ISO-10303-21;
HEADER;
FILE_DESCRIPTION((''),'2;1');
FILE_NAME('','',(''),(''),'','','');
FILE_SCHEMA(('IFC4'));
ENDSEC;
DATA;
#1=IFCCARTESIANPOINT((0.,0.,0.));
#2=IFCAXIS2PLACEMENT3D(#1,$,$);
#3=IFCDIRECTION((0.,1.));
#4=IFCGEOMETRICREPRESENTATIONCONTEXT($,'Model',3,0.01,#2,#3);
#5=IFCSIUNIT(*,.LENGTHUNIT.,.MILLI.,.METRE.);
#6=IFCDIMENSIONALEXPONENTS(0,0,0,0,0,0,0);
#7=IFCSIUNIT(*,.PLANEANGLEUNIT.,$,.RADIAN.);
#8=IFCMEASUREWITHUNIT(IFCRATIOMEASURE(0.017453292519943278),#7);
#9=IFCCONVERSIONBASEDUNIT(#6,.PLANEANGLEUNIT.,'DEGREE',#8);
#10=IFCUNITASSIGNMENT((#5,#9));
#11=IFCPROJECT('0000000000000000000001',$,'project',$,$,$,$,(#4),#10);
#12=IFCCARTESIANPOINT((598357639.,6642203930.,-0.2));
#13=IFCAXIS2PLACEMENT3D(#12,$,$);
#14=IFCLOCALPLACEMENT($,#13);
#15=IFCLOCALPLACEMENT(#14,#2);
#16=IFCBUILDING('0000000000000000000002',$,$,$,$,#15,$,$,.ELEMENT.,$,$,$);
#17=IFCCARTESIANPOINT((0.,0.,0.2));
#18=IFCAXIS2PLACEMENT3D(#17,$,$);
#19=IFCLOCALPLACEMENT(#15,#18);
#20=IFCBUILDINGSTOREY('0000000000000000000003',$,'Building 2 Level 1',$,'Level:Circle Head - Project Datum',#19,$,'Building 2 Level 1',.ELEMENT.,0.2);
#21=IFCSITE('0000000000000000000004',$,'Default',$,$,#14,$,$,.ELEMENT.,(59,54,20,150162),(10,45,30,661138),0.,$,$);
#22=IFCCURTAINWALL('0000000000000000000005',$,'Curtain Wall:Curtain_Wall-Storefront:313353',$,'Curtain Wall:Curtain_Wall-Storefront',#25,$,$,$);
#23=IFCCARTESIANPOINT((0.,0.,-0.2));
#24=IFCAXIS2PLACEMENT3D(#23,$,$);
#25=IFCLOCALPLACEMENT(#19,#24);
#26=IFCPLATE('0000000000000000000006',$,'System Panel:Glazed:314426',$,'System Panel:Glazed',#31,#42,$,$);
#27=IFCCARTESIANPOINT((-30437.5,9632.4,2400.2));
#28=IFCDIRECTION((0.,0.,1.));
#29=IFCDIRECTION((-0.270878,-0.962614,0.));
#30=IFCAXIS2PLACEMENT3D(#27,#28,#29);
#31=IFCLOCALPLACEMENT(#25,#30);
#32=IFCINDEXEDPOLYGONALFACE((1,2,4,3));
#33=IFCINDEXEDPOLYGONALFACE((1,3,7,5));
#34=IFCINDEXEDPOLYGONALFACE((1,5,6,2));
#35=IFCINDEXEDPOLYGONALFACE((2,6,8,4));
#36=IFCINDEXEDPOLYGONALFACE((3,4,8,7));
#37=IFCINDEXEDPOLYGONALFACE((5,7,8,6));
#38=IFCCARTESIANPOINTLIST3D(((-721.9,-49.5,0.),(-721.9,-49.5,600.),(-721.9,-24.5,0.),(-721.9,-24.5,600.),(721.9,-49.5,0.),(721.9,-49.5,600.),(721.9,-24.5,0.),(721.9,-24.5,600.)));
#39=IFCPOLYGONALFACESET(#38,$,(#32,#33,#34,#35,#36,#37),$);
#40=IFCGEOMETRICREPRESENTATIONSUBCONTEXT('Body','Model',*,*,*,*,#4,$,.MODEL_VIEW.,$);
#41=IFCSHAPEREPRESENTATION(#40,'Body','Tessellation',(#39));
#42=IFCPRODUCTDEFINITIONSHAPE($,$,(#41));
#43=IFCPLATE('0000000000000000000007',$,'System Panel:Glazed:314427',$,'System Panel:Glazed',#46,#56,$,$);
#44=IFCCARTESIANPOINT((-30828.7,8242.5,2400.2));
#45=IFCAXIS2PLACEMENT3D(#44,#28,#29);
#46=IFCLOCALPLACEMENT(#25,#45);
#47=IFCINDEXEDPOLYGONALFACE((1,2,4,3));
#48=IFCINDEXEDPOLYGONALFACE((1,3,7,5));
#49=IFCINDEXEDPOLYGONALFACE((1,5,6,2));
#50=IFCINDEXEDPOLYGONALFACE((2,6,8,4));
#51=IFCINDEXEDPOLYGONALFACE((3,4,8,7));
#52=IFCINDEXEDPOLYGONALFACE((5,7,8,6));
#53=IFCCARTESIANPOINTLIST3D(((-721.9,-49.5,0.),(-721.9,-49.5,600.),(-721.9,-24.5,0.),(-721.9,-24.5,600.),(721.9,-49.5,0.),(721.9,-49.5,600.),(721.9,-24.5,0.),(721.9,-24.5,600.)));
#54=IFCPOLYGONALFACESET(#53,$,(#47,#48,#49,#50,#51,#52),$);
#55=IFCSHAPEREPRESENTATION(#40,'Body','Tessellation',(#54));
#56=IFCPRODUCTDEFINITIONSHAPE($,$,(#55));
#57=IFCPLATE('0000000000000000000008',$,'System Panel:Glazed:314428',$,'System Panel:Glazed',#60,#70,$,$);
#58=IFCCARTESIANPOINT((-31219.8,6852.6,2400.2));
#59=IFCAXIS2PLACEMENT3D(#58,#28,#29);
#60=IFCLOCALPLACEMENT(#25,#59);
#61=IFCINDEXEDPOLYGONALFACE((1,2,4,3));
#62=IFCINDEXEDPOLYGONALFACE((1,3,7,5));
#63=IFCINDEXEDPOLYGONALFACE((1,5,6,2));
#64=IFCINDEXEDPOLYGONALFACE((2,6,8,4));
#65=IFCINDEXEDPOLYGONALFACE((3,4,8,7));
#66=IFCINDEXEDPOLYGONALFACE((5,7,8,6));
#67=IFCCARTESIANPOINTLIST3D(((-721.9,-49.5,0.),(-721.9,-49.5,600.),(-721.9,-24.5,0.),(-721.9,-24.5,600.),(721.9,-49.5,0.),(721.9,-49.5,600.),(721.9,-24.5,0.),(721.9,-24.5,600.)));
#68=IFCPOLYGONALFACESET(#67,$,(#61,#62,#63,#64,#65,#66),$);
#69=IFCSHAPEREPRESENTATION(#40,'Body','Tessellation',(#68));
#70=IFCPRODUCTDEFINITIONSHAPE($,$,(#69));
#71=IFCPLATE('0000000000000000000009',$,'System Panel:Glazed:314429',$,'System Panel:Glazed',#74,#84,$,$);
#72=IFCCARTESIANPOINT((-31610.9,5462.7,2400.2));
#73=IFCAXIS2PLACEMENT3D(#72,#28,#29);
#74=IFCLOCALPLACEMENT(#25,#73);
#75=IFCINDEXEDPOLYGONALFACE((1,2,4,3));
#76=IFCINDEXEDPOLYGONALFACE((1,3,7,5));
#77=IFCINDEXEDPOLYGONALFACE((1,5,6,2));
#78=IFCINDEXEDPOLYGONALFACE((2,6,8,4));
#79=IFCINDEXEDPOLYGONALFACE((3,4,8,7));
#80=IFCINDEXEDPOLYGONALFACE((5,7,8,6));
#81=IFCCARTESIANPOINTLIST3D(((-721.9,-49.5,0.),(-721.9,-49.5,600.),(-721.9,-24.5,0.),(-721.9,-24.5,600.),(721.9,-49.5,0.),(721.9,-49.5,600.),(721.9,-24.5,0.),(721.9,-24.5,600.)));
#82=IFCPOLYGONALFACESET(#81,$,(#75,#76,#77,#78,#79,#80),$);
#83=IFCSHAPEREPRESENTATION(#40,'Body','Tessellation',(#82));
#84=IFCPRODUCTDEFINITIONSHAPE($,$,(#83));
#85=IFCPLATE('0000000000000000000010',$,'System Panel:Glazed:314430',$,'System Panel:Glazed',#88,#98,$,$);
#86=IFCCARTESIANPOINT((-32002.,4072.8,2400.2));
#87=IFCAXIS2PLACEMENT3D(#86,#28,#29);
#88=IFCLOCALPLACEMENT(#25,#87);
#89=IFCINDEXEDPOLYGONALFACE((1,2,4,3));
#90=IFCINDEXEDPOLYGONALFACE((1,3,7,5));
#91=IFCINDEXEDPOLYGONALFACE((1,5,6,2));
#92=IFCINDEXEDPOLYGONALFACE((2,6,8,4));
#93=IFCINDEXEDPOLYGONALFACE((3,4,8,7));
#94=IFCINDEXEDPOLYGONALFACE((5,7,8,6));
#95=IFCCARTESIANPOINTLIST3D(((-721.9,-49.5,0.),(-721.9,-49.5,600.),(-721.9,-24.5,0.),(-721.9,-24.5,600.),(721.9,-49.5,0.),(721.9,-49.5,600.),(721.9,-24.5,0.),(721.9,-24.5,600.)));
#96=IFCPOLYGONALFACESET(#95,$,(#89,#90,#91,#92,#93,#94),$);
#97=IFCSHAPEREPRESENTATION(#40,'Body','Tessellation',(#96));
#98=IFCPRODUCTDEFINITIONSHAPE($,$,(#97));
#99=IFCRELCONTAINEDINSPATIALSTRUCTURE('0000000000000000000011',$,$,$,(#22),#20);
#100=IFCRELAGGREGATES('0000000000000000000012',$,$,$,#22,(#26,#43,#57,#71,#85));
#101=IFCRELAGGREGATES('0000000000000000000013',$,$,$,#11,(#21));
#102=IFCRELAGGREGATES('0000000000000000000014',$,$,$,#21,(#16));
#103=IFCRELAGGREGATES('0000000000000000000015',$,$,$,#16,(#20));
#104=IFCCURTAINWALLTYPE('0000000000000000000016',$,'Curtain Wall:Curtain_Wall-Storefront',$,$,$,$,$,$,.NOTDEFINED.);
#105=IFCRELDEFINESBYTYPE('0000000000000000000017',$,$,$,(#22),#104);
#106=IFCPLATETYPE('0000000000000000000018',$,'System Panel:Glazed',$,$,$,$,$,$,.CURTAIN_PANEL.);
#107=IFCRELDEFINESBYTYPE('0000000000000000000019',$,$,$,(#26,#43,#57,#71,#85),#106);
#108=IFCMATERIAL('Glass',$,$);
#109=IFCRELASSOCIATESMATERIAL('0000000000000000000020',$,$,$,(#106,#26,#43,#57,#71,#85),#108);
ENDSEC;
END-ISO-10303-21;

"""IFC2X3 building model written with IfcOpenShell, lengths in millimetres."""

from ifc_helpers import new_model, entity, si_unit, converted_unit, direction, frame, frame_2d, origin, place, context, subcontext, project, spatial, rectangle, extrude, source, transform, mapped, material, type_object, type_shapes, element, aggregate, save


model = new_model("IFC2X3")

# Units and contexts
model_context = context("Model", 3, precision=0.01, world=origin(), true_north=direction((0.0, 1.0)))
body_context = subcontext(model_context, "Body", "Model", "MODEL_VIEW")
ifc_project = project(units=[si_unit("LENGTHUNIT", "METRE", prefix="MILLI"), converted_unit("PLANEANGLEUNIT", "DEGREE", entity("IfcRatioMeasure", 0.017453292519943278), si_unit("PLANEANGLEUNIT", "RADIAN"), dimensions=[0, 0, 0, 0, 0, 0, 0])], contexts=[model_context])

# Site, building, storey
site_placement = place(None, frame((598357639.0, 6642203930.0, -0.2)))
site = spatial("IfcSite", under=ifc_project, at=site_placement, Name="Default", CompositionType="ELEMENT", RefLatitude=(59, 54, 20, 150162), RefLongitude=(10, 45, 30, 661138), RefElevation=0.0)
building_placement = place(site_placement, origin())
building = spatial("IfcBuilding", under=site, at=building_placement, CompositionType="ELEMENT")
storey_placement = place(building_placement, frame((0.0, 0.0, 0.2)))
storey = spatial("IfcBuildingStorey", under=building, at=storey_placement, Name="Building 2 Level 1", ObjectType="Level:Circle Head - Project Datum", LongName="Building 2 Level 1", CompositionType="ELEMENT", Elevation=0.2)

# Curtain wall, plates
curtain_wall_type = type_object("IfcCurtainWallType", Name="Curtain Wall:Curtain_Wall-Storefront", PredefinedType="NOTDEFINED")
ifc_material = material(Name="Glass")
curtain_wall_1_placement = place(storey_placement, frame((0.0, 0.0, -0.2)))
curtain_wall_1 = element("IfcCurtainWall", 1, at=curtain_wall_1_placement, inside=storey, type_object=curtain_wall_type, Name="Curtain Wall:Curtain_Wall-Storefront:313353", ObjectType="Curtain Wall:Curtain_Wall-Storefront")
plate_type_1 = type_object("IfcPlateType", Name="System Panel:Glazed", PredefinedType="CURTAIN_PANEL", material=ifc_material)
shared_shape_1 = source(origin(), body_context, "Body", "SweptSolid", [
    extrude(rectangle(XDim=25.0, YDim=1443.9, at=frame_2d((0.0, 0.0), x_axis=(1.0, 0.0))), frame((0.0, -37.0, 0.0), z_axis=(0.0, 0.0, 1.0), x_axis=(0.0, 1.0, 0.0)), (0.0, 0.0, 1.0), 600.0),
])
type_shapes(plate_type_1, [shared_shape_1])
plate_1_placement = place(curtain_wall_1_placement, frame((-30437.5, 9632.4, 2400.2), z_axis=(0.0, 0.0, 1.0), x_axis=(-0.270878, -0.962614, 0.0)))
plate_1 = element("IfcPlate", 2, at=plate_1_placement, type_object=plate_type_1, material=ifc_material, Name="System Panel:Glazed:314426", ObjectType="System Panel:Glazed", context=body_context, shape_type="MappedRepresentation", body=[
    mapped(shared_shape_1, transform((0.0, 0.0, 0.0), scale=1.0)),
])
plate_2_placement = place(curtain_wall_1_placement, frame((-30828.7, 8242.5, 2400.2), z_axis=(0.0, 0.0, 1.0), x_axis=(-0.270878, -0.962614, 0.0)))
plate_2 = element("IfcPlate", 3, at=plate_2_placement, type_object=plate_type_1, material=ifc_material, Name="System Panel:Glazed:314427", ObjectType="System Panel:Glazed", context=body_context, shape_type="MappedRepresentation", body=[
    mapped(shared_shape_1, transform((0.0, 0.0, 0.0), scale=1.0)),
])
plate_3_placement = place(curtain_wall_1_placement, frame((-31219.8, 6852.6, 2400.2), z_axis=(0.0, 0.0, 1.0), x_axis=(-0.270878, -0.962614, 0.0)))
plate_3 = element("IfcPlate", 4, at=plate_3_placement, type_object=plate_type_1, material=ifc_material, Name="System Panel:Glazed:314428", ObjectType="System Panel:Glazed", context=body_context, shape_type="MappedRepresentation", body=[
    mapped(shared_shape_1, transform((0.0, 0.0, 0.0), scale=1.0)),
])
plate_4_placement = place(curtain_wall_1_placement, frame((-31610.9, 5462.7, 2400.2), z_axis=(0.0, 0.0, 1.0), x_axis=(-0.270878, -0.962614, 0.0)))
plate_4 = element("IfcPlate", 5, at=plate_4_placement, type_object=plate_type_1, material=ifc_material, Name="System Panel:Glazed:314429", ObjectType="System Panel:Glazed", context=body_context, shape_type="MappedRepresentation", body=[
    mapped(shared_shape_1, transform((0.0, 0.0, 0.0), scale=1.0)),
])
plate_5_placement = place(curtain_wall_1_placement, frame((-32002.0, 4072.8, 2400.2), z_axis=(0.0, 0.0, 1.0), x_axis=(-0.270878, -0.962614, 0.0)))
plate_5 = element("IfcPlate", 6, at=plate_5_placement, type_object=plate_type_1, material=ifc_material, Name="System Panel:Glazed:314430", ObjectType="System Panel:Glazed", context=body_context, shape_type="MappedRepresentation", body=[
    mapped(shared_shape_1, transform((0.0, 0.0, 0.0), scale=1.0)),
])
aggregate(curtain_wall_1, [plate_1, plate_2, plate_3, plate_4, plate_5])

save(model, "model.ifc")
